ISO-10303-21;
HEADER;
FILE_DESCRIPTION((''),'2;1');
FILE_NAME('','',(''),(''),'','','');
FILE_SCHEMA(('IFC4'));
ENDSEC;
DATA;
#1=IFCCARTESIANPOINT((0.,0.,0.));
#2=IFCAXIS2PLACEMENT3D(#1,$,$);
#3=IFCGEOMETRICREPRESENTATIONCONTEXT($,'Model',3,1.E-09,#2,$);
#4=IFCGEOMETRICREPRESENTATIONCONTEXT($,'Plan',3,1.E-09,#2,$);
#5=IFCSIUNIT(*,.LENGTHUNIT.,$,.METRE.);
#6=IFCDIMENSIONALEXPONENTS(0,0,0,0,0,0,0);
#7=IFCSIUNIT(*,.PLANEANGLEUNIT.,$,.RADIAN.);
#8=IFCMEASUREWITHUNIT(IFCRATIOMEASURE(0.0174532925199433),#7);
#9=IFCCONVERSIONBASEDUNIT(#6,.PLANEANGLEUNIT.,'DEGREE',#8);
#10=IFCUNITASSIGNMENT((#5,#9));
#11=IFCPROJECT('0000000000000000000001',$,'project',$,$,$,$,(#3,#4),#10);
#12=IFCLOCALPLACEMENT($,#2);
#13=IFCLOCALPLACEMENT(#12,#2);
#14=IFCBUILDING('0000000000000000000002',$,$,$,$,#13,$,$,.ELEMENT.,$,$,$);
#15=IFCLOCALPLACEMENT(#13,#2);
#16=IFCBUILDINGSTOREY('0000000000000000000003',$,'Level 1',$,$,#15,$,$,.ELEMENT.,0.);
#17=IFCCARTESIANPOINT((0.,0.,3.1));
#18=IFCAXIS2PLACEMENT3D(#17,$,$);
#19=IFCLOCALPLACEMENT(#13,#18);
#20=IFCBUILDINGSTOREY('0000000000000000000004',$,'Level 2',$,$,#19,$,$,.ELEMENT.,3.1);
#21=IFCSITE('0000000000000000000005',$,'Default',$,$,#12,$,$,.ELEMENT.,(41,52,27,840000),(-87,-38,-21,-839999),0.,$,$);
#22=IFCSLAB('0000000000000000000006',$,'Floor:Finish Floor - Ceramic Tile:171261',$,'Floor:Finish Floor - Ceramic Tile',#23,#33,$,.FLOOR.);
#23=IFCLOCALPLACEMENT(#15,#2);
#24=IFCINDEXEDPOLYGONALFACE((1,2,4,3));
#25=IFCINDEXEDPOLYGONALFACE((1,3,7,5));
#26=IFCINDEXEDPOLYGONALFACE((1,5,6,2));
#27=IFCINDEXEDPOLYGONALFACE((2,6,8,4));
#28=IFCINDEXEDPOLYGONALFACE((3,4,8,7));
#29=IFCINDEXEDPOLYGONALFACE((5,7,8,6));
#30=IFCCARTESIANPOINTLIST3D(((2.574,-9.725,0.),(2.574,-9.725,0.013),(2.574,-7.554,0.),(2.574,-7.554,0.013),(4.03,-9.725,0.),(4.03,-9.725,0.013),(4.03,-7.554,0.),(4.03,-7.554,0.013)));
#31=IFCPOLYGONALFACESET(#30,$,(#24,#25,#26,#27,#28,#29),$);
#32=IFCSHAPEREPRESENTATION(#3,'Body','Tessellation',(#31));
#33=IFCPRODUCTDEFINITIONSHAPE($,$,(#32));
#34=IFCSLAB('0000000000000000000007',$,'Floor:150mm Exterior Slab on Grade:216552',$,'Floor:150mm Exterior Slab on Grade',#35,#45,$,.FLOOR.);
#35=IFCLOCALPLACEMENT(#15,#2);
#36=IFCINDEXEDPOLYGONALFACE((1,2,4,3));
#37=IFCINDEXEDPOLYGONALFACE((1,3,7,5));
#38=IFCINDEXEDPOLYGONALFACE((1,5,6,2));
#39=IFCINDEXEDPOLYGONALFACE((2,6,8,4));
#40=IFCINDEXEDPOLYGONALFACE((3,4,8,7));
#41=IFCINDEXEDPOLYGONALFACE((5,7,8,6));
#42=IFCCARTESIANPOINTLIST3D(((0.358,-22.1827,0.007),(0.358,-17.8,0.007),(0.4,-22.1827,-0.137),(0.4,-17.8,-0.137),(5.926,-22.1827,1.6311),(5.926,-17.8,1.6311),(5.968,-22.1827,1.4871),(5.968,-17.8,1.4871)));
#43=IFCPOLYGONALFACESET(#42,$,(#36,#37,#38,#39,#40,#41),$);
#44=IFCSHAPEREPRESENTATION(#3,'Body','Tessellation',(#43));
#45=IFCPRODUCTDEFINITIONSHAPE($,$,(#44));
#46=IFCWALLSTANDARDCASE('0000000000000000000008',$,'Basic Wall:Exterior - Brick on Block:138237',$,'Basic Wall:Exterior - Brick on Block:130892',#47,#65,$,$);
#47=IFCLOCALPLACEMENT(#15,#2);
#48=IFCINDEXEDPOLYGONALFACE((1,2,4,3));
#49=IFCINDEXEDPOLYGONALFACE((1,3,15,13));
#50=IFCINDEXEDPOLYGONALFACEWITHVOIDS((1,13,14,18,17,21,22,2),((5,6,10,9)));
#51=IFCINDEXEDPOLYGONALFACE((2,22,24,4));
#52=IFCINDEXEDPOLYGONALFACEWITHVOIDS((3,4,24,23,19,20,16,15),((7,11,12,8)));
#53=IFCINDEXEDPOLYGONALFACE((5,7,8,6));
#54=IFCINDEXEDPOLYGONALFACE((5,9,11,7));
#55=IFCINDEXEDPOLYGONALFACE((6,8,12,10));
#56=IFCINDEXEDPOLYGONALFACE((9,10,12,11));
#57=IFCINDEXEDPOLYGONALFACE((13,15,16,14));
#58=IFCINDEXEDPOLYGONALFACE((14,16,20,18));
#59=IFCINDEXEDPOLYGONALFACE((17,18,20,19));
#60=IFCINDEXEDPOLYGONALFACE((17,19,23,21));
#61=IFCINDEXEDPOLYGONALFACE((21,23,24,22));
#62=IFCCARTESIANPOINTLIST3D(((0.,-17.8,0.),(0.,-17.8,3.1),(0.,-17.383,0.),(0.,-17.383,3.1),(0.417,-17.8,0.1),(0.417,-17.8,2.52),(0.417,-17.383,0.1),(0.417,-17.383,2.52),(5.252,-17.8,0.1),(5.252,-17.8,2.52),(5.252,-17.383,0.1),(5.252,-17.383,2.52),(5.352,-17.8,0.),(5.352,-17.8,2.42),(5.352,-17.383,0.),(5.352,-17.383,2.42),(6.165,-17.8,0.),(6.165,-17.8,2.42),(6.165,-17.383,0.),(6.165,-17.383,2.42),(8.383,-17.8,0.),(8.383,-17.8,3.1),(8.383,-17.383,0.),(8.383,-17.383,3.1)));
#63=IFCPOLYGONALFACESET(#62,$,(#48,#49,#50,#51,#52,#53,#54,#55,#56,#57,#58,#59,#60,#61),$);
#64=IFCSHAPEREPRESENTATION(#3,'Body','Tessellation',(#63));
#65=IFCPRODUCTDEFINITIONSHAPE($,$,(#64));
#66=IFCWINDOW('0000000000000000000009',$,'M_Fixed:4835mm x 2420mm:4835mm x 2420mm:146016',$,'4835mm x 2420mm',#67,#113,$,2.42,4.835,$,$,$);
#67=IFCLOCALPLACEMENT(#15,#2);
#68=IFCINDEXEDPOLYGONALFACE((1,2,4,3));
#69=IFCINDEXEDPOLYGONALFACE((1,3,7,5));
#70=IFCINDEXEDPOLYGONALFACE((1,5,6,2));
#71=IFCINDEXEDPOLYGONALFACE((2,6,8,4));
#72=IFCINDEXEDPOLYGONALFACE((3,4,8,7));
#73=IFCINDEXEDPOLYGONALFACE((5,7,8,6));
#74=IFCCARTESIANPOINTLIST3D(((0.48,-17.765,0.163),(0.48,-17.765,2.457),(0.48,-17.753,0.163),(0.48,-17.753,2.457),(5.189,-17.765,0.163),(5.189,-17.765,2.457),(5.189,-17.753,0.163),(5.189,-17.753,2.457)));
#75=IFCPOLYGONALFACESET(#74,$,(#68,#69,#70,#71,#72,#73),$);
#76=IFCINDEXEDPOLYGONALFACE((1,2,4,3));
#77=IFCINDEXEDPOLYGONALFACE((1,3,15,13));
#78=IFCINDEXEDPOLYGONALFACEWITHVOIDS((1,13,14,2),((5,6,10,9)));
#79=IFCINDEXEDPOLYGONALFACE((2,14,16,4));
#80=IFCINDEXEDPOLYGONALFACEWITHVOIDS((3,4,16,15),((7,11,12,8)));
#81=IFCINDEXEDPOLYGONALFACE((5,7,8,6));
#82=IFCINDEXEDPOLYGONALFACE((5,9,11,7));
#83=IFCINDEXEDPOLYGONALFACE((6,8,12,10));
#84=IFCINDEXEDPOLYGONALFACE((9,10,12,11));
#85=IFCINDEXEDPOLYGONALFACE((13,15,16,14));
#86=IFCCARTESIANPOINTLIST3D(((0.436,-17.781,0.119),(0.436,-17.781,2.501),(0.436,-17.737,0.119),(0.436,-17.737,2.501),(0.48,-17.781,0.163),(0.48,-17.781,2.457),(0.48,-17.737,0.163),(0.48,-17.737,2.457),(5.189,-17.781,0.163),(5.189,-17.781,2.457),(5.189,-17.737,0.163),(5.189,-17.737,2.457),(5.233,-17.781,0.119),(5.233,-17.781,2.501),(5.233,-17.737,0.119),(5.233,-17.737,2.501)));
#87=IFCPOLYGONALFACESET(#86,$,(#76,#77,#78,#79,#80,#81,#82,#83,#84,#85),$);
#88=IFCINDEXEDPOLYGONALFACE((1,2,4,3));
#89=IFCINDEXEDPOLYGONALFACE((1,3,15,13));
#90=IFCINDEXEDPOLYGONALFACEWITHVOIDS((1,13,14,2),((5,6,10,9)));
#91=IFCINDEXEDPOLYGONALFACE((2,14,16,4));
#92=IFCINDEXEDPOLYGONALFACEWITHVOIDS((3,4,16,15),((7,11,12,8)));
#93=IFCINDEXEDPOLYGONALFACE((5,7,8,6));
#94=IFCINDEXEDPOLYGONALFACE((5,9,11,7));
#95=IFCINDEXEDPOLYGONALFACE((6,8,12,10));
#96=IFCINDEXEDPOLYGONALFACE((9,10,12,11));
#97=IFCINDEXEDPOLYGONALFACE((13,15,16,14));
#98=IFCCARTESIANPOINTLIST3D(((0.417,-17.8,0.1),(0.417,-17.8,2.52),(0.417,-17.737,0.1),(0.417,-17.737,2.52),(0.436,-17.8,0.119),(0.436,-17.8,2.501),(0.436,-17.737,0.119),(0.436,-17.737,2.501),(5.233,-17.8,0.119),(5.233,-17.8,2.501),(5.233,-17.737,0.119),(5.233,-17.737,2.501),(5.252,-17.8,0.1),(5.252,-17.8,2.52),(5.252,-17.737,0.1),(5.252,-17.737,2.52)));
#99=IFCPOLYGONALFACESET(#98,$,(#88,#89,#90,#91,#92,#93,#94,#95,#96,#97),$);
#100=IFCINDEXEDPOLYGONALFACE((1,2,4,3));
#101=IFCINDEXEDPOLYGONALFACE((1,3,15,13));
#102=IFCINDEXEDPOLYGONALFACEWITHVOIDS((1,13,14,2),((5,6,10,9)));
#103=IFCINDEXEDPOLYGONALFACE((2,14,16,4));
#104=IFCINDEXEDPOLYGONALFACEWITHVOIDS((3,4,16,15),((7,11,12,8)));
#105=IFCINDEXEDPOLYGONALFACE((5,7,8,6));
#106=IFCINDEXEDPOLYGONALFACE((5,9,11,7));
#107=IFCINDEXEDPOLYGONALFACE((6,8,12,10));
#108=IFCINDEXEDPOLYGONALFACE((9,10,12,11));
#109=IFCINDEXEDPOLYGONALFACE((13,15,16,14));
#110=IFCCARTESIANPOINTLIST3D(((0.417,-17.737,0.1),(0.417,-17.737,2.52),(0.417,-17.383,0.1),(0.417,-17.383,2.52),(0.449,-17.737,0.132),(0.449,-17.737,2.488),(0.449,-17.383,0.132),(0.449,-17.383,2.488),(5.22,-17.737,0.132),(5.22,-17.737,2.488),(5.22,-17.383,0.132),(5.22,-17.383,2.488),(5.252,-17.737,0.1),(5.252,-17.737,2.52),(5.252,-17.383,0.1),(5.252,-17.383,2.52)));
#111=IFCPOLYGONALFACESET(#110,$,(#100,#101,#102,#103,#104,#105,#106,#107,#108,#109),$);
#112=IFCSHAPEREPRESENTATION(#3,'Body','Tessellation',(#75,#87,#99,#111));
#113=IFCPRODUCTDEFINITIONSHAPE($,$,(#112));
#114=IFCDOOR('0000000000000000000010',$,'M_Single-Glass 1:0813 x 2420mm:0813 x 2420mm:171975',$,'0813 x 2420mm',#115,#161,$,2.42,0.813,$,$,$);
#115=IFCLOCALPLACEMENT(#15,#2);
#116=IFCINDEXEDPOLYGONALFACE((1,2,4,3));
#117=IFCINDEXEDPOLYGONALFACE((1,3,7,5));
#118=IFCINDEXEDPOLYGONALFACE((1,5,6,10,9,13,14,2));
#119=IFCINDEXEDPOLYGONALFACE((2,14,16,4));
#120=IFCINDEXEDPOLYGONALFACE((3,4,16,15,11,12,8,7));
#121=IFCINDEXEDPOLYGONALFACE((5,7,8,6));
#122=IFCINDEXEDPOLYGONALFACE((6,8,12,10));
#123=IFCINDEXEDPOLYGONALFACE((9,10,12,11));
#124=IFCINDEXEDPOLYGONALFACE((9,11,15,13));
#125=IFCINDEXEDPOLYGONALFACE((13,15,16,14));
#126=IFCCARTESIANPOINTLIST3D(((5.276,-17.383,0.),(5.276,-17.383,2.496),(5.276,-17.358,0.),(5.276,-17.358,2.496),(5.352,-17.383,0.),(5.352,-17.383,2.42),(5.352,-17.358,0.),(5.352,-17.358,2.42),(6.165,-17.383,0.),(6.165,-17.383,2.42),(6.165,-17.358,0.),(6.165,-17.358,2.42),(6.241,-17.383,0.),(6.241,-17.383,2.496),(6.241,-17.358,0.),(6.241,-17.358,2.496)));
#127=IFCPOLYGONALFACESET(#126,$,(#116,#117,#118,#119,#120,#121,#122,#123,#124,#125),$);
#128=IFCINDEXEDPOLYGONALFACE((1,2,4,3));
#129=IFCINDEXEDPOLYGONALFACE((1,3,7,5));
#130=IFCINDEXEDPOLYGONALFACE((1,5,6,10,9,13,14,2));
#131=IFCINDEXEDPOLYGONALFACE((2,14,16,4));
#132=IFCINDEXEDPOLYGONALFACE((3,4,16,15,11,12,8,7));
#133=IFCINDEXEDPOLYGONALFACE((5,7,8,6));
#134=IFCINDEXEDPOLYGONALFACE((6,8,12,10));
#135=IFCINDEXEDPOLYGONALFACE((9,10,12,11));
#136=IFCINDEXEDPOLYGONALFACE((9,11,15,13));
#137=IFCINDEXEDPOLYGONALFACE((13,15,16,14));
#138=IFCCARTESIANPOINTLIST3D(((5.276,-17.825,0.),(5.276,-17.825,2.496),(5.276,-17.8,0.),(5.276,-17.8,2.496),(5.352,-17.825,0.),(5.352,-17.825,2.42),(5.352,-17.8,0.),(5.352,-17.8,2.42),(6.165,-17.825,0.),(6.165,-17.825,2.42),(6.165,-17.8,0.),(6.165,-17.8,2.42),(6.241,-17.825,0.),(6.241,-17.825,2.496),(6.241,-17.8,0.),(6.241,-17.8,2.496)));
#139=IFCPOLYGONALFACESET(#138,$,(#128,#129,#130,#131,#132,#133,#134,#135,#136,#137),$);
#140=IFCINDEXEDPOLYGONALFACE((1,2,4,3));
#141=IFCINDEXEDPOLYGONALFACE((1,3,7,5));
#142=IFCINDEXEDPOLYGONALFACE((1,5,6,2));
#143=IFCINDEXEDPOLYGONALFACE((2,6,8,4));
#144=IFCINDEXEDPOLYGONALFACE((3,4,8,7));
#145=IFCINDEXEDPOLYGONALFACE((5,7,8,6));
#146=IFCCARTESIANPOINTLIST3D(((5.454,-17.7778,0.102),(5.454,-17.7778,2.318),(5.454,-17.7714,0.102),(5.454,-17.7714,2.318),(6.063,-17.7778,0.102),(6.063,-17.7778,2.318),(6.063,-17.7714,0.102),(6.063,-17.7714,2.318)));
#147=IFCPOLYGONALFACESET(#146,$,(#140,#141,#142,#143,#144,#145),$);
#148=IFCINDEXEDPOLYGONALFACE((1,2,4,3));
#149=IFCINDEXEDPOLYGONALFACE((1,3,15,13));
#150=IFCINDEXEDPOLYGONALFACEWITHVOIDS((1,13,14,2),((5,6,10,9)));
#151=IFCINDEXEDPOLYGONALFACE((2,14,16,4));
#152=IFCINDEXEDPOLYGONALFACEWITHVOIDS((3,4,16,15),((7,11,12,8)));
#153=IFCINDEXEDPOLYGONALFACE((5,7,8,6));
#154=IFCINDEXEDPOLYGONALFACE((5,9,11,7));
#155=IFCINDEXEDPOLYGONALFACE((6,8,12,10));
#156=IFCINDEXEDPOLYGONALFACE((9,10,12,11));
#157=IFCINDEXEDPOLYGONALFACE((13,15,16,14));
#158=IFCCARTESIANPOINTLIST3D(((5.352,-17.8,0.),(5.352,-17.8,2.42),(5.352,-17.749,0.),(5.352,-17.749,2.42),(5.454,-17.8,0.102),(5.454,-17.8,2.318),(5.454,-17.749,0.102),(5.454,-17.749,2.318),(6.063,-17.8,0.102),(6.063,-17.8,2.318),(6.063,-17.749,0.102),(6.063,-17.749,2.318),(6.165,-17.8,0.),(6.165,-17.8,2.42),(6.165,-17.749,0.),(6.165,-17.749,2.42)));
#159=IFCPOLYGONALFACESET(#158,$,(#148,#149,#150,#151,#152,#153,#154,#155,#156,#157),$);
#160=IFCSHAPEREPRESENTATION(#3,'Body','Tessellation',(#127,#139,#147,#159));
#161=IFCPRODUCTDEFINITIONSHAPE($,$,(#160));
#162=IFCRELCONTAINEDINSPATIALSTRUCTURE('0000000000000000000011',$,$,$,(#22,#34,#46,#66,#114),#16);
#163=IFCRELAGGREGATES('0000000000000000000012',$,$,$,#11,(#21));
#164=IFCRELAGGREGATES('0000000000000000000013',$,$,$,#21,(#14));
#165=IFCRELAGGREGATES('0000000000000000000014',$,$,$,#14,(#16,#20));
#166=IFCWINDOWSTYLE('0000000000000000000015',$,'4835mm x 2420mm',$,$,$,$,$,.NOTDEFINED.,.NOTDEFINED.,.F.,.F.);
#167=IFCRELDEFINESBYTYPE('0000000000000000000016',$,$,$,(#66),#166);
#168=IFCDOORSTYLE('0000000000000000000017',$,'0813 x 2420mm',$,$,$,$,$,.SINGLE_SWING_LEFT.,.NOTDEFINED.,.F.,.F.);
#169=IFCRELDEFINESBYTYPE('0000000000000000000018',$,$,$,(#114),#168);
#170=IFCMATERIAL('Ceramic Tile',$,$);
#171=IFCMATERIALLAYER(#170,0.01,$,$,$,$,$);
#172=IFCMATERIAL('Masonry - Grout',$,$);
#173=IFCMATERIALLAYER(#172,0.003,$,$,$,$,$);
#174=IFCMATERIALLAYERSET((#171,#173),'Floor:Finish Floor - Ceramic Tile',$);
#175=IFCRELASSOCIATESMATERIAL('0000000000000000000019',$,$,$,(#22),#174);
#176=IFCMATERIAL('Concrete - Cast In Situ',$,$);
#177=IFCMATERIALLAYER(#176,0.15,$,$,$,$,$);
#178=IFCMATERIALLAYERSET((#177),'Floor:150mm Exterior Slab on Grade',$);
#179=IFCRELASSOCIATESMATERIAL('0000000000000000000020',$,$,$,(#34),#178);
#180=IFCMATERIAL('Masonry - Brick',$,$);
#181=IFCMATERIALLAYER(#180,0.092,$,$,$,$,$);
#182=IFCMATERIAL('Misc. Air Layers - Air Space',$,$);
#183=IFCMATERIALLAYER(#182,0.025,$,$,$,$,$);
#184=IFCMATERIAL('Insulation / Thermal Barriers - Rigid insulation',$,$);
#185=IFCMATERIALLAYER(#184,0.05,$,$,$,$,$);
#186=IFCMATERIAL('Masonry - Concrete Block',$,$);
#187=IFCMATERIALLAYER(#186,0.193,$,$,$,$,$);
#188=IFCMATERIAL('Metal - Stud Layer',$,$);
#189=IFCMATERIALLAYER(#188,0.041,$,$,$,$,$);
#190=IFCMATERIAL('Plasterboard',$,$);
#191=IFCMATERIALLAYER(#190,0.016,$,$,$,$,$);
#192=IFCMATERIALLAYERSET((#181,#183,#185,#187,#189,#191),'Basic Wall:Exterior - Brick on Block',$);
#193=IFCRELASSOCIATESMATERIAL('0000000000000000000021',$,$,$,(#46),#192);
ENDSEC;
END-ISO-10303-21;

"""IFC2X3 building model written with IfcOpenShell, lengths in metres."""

from ifc_helpers import new_model, entity, si_unit, converted_unit, frame, frame_2d, origin, origin_2d_with_axis, place, context, project, spatial, polyline, rectangle, outline, extrude, source, transform, mapped, material, layer, layer_set, layer_usage, type_object, type_shapes, element, fill, save


model = new_model("IFC2X3")

# Units and contexts
model_context = context("Model", 3, precision=1e-09, world=origin())
plan_context = context("Plan", 3, precision=1e-09, world=origin())
ifc_project = project(units=[si_unit("LENGTHUNIT", "METRE"), converted_unit("PLANEANGLEUNIT", "DEGREE", entity("IfcRatioMeasure", 0.0174532925199433), si_unit("PLANEANGLEUNIT", "RADIAN"), dimensions=[0, 0, 0, 0, 0, 0, 0])], contexts=[model_context, plan_context])

# Site, building, storey
site_placement = place(None, origin())
site = spatial("IfcSite", under=ifc_project, at=site_placement, Name="Default", CompositionType="ELEMENT", RefLatitude=(41, 52, 27, 840000), RefLongitude=(-87, -38, -21, -839999), RefElevation=0.0)
building_placement = place(site_placement, origin())
building = spatial("IfcBuilding", under=site, at=building_placement, CompositionType="ELEMENT")
storey_1_placement = place(building_placement, origin())
storey_1 = spatial("IfcBuildingStorey", under=building, at=storey_1_placement, Name="Level 1", CompositionType="ELEMENT", Elevation=0.0)

# Slabs
ifc_material_1 = material(Name="Ceramic Tile")
ifc_layer_1 = layer(ifc_material_1, 0.01)
ifc_material_2 = material(Name="Masonry - Grout")
ifc_layer_2 = layer(ifc_material_2, 0.003)
ifc_layer_set_1 = layer_set([ifc_layer_1, ifc_layer_2], Name="Floor:Finish Floor - Ceramic Tile")
ifc_layer_usage_1 = layer_usage(ifc_layer_set_1, "AXIS3", "POSITIVE", 0.0)
slab_1_placement = place(storey_1_placement, frame((2.574, -9.725, 0.0)))
element("IfcSlab", 1, at=slab_1_placement, inside=storey_1, material=ifc_layer_usage_1, Name="Floor:Finish Floor - Ceramic Tile:171261", ObjectType="Floor:Finish Floor - Ceramic Tile", PredefinedType="FLOOR", context=model_context, shape_type="SweptSolid", body=[
    extrude(rectangle(XDim=2.171, YDim=1.456, at=frame_2d((0.0, 0.0), x_axis=(0.0, -1.0))), frame((0.728, 1.0855, 0.013), z_axis=(0.0, 0.0, -1.0), x_axis=(-1.0, 0.0, 0.0)), (0.0, 0.0, 1.0), 0.013),
])
ifc_material_3 = material(Name="Concrete - Cast In Situ")
ifc_layer_3 = layer(ifc_material_3, 0.15)
ifc_layer_set_2 = layer_set([ifc_layer_3], Name="Floor:150mm Exterior Slab on Grade")
ifc_layer_usage_2 = layer_usage(ifc_layer_set_2, "AXIS3", "POSITIVE", 0.0)
slab_2_placement = place(storey_1_placement, frame((0.4, -22.1827, -0.137), z_axis=(-0.280012, 0.0, 0.959996), x_axis=(0.959996, 0.0, 0.280012)))
element("IfcSlab", 2, at=slab_2_placement, inside=storey_1, material=ifc_layer_usage_2, Name="Floor:150mm Exterior Slab on Grade:216552", ObjectType="Floor:150mm Exterior Slab on Grade", PredefinedType="FLOOR", context=model_context, shape_type="SweptSolid", body=[
    extrude(rectangle(XDim=5.8, YDim=4.3827, at=origin_2d_with_axis()), frame((2.9, 2.1914, 0.15), z_axis=(0.0, 0.0, -1.0), x_axis=(-1.0, 0.0, 0.0)), (0.0, 0.0, 1.0), 0.15),
])

# Wall, openings, window, door
ifc_material_4 = material(Name="Masonry - Brick")
ifc_layer_4 = layer(ifc_material_4, 0.092)
ifc_material_5 = material(Name="Misc. Air Layers - Air Space")
ifc_layer_5 = layer(ifc_material_5, 0.025)
ifc_material_6 = material(Name="Insulation / Thermal Barriers - Rigid insulation")
ifc_layer_6 = layer(ifc_material_6, 0.05)
ifc_material_7 = material(Name="Masonry - Concrete Block")
ifc_layer_7 = layer(ifc_material_7, 0.193)
ifc_material_8 = material(Name="Metal - Stud Layer")
ifc_layer_8 = layer(ifc_material_8, 0.041)
ifc_material_9 = material(Name="Plasterboard")
ifc_layer_9 = layer(ifc_material_9, 0.016)
ifc_layer_set_3 = layer_set([ifc_layer_4, ifc_layer_5, ifc_layer_6, ifc_layer_7, ifc_layer_8, ifc_layer_9], Name="Basic Wall:Exterior - Brick on Block")
ifc_layer_usage_3 = layer_usage(ifc_layer_set_3, "AXIS2", "NEGATIVE", 0.2085)
wall_1_placement = place(storey_1_placement, frame((8.383, -17.5915, 0.0), z_axis=(0.0, 0.0, 1.0), x_axis=(-1.0, 0.0, 0.0)))
wall_1 = element("IfcWallStandardCase", 3, at=wall_1_placement, inside=storey_1, material=ifc_layer_usage_3, Name="Basic Wall:Exterior - Brick on Block:138237", ObjectType="Basic Wall:Exterior - Brick on Block:130892", context=model_context, shape_type="SweptSolid", body=[
    extrude(rectangle(XDim=8.383, YDim=0.417, at=frame_2d((4.1915, 0.0), x_axis=(-1.0, 0.0))), origin(), (0.0, 0.0, 1.0), 3.1),
])
opening_1_placement = place(wall_1_placement, frame((3.131, -0.2085, 0.1)))
opening_1 = element("IfcOpeningElement", 4, at=opening_1_placement, cuts=wall_1, ObjectType="Opening", context=model_context, shape_type="SweptSolid", body=[
    extrude(rectangle(XDim=2.42, YDim=4.835, at=frame_2d((1.21, 2.4175), x_axis=(1.0, 0.0))), frame((0.0, 0.0, 0.0), z_axis=(0.0, 1.0, 0.0), x_axis=(0.0, 0.0, 1.0)), (0.0, 0.0, 1.0), 0.417),
])
opening_2_placement = place(wall_1_placement, frame((2.218, -0.2085, 0.0)))
opening_2 = element("IfcOpeningElement", 5, at=opening_2_placement, cuts=wall_1, ObjectType="Opening", context=model_context, shape_type="SweptSolid", body=[
    extrude(rectangle(XDim=0.813, YDim=2.42, at=frame_2d((1.21, 0.4065), x_axis=(0.0, -1.0))), frame((0.0, 0.0, 0.0), z_axis=(0.0, 1.0, 0.0), x_axis=(0.0, 0.0, 1.0)), (0.0, 0.0, 1.0), 0.417),
])
window_style_1 = type_object("IfcWindowStyle", Name="4835mm x 2420mm", ConstructionType="NOTDEFINED", OperationType="NOTDEFINED", ParameterTakesPrecedence=False, Sizeable=False)
shared_shape_1 = source(origin(), model_context, "Body", "SweptSolid", [
    extrude(rectangle(XDim=0.012, YDim=4.709, at=origin_2d_with_axis()), frame((2.4175, 0.376, 0.063), z_axis=(0.0, 0.0, 1.0), x_axis=(0.0, -1.0, 0.0)), (0.0, 0.0, 1.0), 2.294),
    extrude(outline(polyline([(-2.3985, -1.191), (2.3985, -1.191), (2.3985, 1.191), (-2.3985, 1.191), (-2.3985, -1.191)]), holes=[polyline([(-2.3545, -1.147), (-2.3545, 1.147), (2.3545, 1.147), (2.3545, -1.147), (-2.3545, -1.147)])]), frame((2.4175, 0.354, 1.21), z_axis=(0.0, 1.0, 0.0), x_axis=(1.0, 0.0, 0.0)), (0.0, 0.0, 1.0), 0.044),
    extrude(outline(polyline([(-2.4175, -1.21), (2.4175, -1.21), (2.4175, 1.21), (-2.4175, 1.21), (-2.4175, -1.21)]), holes=[polyline([(-2.3985, -1.191), (-2.3985, 1.191), (2.3985, 1.191), (2.3985, -1.191), (-2.3985, -1.191)])]), frame((2.4175, 0.354, 1.21), z_axis=(0.0, 1.0, 0.0), x_axis=(1.0, 0.0, 0.0)), (0.0, 0.0, 1.0), 0.063),
    extrude(outline(polyline([(-2.4175, -1.21), (2.4175, -1.21), (2.4175, 1.21), (-2.4175, 1.21), (-2.4175, -1.21)]), holes=[polyline([(-2.3855, -1.178), (-2.3855, 1.178), (2.3855, 1.178), (2.3855, -1.178), (-2.3855, -1.178)])]), frame((2.4175, 0.0, 1.21), z_axis=(0.0, 1.0, 0.0), x_axis=(1.0, 0.0, 0.0)), (0.0, 0.0, 1.0), 0.354),
])
type_shapes(window_style_1, [shared_shape_1])
window_1_placement = place(opening_1_placement, origin())
window_1 = element("IfcWindow", 6, at=window_1_placement, inside=storey_1, type_object=window_style_1, Name="M_Fixed:4835mm x 2420mm:4835mm x 2420mm:146016", ObjectType="4835mm x 2420mm", OverallHeight=2.42, OverallWidth=4.835, context=model_context, shape_type="MappedRepresentation", body=[
    mapped(shared_shape_1, transform((0.0, 0.0, 0.0), scale=1.0)),
])
fill(opening_1, window_1)
door_style_1 = type_object("IfcDoorStyle", Name="0813 x 2420mm", ConstructionType="NOTDEFINED", OperationType="SINGLE_SWING_LEFT", ParameterTakesPrecedence=False, Sizeable=False)
shared_shape_2 = source(origin(), model_context, "Body", "SweptSolid", [
    extrude(outline(polyline([(-0.4065, -1.191), (-0.4065, 1.229), (-0.4825, 1.229), (-0.4825, -1.267), (0.4825, -1.267), (0.4825, 1.229), (0.4065, 1.229), (0.4065, -1.191), (-0.4065, -1.191)])), frame((0.4065, 0.0, 1.229), z_axis=(0.0, 1.0, 0.0), x_axis=(1.0, 0.0, 0.0)), (0.0, 0.0, -1.0), 0.025),
    extrude(outline(polyline([(-0.4065, -1.191), (-0.4065, 1.229), (-0.4825, 1.229), (-0.4825, -1.267), (0.4825, -1.267), (0.4825, 1.229), (0.4065, 1.229), (0.4065, -1.191), (-0.4065, -1.191)])), frame((0.4065, 0.442, 1.229), z_axis=(0.0, 1.0, 0.0), x_axis=(1.0, 0.0, 0.0)), (0.0, 0.0, -1.0), 0.025),
    extrude(rectangle(XDim=0.609, YDim=0.0064, at=origin_2d_with_axis()), frame((0.4065, 0.3916, 0.102)), (0.0, 0.0, 1.0), 2.216),
    extrude(outline(polyline([(-1.21, -0.4065), (1.21, -0.4065), (1.21, 0.4065), (-1.21, 0.4065), (-1.21, -0.4065)]), holes=[polyline([(-1.108, 0.3045), (1.108, 0.3045), (1.108, -0.3045), (-1.108, -0.3045), (-1.108, 0.3045)])]), frame((0.4065, 0.417, 1.21), z_axis=(0.0, -1.0, 0.0), x_axis=(0.0, 0.0, -1.0)), (0.0, 0.0, 1.0), 0.051),
])
type_shapes(door_style_1, [shared_shape_2])
door_1_placement = place(opening_2_placement, origin())
door_1 = element("IfcDoor", 7, at=door_1_placement, inside=storey_1, type_object=door_style_1, Name="M_Single-Glass 1:0813 x 2420mm:0813 x 2420mm:171975", ObjectType="0813 x 2420mm", OverallHeight=2.42, OverallWidth=0.813, context=model_context, shape_type="MappedRepresentation", body=[
    mapped(shared_shape_2, transform((0.0, 0.0, 0.0), scale=1.0)),
])
fill(opening_2, door_1)

# Shared definitions
storey_2_placement = place(building_placement, frame((0.0, 0.0, 3.1)))
storey_2 = spatial("IfcBuildingStorey", under=building, at=storey_2_placement, Name="Level 2", CompositionType="ELEMENT", Elevation=3.1)

save(model, "model.ifc")
